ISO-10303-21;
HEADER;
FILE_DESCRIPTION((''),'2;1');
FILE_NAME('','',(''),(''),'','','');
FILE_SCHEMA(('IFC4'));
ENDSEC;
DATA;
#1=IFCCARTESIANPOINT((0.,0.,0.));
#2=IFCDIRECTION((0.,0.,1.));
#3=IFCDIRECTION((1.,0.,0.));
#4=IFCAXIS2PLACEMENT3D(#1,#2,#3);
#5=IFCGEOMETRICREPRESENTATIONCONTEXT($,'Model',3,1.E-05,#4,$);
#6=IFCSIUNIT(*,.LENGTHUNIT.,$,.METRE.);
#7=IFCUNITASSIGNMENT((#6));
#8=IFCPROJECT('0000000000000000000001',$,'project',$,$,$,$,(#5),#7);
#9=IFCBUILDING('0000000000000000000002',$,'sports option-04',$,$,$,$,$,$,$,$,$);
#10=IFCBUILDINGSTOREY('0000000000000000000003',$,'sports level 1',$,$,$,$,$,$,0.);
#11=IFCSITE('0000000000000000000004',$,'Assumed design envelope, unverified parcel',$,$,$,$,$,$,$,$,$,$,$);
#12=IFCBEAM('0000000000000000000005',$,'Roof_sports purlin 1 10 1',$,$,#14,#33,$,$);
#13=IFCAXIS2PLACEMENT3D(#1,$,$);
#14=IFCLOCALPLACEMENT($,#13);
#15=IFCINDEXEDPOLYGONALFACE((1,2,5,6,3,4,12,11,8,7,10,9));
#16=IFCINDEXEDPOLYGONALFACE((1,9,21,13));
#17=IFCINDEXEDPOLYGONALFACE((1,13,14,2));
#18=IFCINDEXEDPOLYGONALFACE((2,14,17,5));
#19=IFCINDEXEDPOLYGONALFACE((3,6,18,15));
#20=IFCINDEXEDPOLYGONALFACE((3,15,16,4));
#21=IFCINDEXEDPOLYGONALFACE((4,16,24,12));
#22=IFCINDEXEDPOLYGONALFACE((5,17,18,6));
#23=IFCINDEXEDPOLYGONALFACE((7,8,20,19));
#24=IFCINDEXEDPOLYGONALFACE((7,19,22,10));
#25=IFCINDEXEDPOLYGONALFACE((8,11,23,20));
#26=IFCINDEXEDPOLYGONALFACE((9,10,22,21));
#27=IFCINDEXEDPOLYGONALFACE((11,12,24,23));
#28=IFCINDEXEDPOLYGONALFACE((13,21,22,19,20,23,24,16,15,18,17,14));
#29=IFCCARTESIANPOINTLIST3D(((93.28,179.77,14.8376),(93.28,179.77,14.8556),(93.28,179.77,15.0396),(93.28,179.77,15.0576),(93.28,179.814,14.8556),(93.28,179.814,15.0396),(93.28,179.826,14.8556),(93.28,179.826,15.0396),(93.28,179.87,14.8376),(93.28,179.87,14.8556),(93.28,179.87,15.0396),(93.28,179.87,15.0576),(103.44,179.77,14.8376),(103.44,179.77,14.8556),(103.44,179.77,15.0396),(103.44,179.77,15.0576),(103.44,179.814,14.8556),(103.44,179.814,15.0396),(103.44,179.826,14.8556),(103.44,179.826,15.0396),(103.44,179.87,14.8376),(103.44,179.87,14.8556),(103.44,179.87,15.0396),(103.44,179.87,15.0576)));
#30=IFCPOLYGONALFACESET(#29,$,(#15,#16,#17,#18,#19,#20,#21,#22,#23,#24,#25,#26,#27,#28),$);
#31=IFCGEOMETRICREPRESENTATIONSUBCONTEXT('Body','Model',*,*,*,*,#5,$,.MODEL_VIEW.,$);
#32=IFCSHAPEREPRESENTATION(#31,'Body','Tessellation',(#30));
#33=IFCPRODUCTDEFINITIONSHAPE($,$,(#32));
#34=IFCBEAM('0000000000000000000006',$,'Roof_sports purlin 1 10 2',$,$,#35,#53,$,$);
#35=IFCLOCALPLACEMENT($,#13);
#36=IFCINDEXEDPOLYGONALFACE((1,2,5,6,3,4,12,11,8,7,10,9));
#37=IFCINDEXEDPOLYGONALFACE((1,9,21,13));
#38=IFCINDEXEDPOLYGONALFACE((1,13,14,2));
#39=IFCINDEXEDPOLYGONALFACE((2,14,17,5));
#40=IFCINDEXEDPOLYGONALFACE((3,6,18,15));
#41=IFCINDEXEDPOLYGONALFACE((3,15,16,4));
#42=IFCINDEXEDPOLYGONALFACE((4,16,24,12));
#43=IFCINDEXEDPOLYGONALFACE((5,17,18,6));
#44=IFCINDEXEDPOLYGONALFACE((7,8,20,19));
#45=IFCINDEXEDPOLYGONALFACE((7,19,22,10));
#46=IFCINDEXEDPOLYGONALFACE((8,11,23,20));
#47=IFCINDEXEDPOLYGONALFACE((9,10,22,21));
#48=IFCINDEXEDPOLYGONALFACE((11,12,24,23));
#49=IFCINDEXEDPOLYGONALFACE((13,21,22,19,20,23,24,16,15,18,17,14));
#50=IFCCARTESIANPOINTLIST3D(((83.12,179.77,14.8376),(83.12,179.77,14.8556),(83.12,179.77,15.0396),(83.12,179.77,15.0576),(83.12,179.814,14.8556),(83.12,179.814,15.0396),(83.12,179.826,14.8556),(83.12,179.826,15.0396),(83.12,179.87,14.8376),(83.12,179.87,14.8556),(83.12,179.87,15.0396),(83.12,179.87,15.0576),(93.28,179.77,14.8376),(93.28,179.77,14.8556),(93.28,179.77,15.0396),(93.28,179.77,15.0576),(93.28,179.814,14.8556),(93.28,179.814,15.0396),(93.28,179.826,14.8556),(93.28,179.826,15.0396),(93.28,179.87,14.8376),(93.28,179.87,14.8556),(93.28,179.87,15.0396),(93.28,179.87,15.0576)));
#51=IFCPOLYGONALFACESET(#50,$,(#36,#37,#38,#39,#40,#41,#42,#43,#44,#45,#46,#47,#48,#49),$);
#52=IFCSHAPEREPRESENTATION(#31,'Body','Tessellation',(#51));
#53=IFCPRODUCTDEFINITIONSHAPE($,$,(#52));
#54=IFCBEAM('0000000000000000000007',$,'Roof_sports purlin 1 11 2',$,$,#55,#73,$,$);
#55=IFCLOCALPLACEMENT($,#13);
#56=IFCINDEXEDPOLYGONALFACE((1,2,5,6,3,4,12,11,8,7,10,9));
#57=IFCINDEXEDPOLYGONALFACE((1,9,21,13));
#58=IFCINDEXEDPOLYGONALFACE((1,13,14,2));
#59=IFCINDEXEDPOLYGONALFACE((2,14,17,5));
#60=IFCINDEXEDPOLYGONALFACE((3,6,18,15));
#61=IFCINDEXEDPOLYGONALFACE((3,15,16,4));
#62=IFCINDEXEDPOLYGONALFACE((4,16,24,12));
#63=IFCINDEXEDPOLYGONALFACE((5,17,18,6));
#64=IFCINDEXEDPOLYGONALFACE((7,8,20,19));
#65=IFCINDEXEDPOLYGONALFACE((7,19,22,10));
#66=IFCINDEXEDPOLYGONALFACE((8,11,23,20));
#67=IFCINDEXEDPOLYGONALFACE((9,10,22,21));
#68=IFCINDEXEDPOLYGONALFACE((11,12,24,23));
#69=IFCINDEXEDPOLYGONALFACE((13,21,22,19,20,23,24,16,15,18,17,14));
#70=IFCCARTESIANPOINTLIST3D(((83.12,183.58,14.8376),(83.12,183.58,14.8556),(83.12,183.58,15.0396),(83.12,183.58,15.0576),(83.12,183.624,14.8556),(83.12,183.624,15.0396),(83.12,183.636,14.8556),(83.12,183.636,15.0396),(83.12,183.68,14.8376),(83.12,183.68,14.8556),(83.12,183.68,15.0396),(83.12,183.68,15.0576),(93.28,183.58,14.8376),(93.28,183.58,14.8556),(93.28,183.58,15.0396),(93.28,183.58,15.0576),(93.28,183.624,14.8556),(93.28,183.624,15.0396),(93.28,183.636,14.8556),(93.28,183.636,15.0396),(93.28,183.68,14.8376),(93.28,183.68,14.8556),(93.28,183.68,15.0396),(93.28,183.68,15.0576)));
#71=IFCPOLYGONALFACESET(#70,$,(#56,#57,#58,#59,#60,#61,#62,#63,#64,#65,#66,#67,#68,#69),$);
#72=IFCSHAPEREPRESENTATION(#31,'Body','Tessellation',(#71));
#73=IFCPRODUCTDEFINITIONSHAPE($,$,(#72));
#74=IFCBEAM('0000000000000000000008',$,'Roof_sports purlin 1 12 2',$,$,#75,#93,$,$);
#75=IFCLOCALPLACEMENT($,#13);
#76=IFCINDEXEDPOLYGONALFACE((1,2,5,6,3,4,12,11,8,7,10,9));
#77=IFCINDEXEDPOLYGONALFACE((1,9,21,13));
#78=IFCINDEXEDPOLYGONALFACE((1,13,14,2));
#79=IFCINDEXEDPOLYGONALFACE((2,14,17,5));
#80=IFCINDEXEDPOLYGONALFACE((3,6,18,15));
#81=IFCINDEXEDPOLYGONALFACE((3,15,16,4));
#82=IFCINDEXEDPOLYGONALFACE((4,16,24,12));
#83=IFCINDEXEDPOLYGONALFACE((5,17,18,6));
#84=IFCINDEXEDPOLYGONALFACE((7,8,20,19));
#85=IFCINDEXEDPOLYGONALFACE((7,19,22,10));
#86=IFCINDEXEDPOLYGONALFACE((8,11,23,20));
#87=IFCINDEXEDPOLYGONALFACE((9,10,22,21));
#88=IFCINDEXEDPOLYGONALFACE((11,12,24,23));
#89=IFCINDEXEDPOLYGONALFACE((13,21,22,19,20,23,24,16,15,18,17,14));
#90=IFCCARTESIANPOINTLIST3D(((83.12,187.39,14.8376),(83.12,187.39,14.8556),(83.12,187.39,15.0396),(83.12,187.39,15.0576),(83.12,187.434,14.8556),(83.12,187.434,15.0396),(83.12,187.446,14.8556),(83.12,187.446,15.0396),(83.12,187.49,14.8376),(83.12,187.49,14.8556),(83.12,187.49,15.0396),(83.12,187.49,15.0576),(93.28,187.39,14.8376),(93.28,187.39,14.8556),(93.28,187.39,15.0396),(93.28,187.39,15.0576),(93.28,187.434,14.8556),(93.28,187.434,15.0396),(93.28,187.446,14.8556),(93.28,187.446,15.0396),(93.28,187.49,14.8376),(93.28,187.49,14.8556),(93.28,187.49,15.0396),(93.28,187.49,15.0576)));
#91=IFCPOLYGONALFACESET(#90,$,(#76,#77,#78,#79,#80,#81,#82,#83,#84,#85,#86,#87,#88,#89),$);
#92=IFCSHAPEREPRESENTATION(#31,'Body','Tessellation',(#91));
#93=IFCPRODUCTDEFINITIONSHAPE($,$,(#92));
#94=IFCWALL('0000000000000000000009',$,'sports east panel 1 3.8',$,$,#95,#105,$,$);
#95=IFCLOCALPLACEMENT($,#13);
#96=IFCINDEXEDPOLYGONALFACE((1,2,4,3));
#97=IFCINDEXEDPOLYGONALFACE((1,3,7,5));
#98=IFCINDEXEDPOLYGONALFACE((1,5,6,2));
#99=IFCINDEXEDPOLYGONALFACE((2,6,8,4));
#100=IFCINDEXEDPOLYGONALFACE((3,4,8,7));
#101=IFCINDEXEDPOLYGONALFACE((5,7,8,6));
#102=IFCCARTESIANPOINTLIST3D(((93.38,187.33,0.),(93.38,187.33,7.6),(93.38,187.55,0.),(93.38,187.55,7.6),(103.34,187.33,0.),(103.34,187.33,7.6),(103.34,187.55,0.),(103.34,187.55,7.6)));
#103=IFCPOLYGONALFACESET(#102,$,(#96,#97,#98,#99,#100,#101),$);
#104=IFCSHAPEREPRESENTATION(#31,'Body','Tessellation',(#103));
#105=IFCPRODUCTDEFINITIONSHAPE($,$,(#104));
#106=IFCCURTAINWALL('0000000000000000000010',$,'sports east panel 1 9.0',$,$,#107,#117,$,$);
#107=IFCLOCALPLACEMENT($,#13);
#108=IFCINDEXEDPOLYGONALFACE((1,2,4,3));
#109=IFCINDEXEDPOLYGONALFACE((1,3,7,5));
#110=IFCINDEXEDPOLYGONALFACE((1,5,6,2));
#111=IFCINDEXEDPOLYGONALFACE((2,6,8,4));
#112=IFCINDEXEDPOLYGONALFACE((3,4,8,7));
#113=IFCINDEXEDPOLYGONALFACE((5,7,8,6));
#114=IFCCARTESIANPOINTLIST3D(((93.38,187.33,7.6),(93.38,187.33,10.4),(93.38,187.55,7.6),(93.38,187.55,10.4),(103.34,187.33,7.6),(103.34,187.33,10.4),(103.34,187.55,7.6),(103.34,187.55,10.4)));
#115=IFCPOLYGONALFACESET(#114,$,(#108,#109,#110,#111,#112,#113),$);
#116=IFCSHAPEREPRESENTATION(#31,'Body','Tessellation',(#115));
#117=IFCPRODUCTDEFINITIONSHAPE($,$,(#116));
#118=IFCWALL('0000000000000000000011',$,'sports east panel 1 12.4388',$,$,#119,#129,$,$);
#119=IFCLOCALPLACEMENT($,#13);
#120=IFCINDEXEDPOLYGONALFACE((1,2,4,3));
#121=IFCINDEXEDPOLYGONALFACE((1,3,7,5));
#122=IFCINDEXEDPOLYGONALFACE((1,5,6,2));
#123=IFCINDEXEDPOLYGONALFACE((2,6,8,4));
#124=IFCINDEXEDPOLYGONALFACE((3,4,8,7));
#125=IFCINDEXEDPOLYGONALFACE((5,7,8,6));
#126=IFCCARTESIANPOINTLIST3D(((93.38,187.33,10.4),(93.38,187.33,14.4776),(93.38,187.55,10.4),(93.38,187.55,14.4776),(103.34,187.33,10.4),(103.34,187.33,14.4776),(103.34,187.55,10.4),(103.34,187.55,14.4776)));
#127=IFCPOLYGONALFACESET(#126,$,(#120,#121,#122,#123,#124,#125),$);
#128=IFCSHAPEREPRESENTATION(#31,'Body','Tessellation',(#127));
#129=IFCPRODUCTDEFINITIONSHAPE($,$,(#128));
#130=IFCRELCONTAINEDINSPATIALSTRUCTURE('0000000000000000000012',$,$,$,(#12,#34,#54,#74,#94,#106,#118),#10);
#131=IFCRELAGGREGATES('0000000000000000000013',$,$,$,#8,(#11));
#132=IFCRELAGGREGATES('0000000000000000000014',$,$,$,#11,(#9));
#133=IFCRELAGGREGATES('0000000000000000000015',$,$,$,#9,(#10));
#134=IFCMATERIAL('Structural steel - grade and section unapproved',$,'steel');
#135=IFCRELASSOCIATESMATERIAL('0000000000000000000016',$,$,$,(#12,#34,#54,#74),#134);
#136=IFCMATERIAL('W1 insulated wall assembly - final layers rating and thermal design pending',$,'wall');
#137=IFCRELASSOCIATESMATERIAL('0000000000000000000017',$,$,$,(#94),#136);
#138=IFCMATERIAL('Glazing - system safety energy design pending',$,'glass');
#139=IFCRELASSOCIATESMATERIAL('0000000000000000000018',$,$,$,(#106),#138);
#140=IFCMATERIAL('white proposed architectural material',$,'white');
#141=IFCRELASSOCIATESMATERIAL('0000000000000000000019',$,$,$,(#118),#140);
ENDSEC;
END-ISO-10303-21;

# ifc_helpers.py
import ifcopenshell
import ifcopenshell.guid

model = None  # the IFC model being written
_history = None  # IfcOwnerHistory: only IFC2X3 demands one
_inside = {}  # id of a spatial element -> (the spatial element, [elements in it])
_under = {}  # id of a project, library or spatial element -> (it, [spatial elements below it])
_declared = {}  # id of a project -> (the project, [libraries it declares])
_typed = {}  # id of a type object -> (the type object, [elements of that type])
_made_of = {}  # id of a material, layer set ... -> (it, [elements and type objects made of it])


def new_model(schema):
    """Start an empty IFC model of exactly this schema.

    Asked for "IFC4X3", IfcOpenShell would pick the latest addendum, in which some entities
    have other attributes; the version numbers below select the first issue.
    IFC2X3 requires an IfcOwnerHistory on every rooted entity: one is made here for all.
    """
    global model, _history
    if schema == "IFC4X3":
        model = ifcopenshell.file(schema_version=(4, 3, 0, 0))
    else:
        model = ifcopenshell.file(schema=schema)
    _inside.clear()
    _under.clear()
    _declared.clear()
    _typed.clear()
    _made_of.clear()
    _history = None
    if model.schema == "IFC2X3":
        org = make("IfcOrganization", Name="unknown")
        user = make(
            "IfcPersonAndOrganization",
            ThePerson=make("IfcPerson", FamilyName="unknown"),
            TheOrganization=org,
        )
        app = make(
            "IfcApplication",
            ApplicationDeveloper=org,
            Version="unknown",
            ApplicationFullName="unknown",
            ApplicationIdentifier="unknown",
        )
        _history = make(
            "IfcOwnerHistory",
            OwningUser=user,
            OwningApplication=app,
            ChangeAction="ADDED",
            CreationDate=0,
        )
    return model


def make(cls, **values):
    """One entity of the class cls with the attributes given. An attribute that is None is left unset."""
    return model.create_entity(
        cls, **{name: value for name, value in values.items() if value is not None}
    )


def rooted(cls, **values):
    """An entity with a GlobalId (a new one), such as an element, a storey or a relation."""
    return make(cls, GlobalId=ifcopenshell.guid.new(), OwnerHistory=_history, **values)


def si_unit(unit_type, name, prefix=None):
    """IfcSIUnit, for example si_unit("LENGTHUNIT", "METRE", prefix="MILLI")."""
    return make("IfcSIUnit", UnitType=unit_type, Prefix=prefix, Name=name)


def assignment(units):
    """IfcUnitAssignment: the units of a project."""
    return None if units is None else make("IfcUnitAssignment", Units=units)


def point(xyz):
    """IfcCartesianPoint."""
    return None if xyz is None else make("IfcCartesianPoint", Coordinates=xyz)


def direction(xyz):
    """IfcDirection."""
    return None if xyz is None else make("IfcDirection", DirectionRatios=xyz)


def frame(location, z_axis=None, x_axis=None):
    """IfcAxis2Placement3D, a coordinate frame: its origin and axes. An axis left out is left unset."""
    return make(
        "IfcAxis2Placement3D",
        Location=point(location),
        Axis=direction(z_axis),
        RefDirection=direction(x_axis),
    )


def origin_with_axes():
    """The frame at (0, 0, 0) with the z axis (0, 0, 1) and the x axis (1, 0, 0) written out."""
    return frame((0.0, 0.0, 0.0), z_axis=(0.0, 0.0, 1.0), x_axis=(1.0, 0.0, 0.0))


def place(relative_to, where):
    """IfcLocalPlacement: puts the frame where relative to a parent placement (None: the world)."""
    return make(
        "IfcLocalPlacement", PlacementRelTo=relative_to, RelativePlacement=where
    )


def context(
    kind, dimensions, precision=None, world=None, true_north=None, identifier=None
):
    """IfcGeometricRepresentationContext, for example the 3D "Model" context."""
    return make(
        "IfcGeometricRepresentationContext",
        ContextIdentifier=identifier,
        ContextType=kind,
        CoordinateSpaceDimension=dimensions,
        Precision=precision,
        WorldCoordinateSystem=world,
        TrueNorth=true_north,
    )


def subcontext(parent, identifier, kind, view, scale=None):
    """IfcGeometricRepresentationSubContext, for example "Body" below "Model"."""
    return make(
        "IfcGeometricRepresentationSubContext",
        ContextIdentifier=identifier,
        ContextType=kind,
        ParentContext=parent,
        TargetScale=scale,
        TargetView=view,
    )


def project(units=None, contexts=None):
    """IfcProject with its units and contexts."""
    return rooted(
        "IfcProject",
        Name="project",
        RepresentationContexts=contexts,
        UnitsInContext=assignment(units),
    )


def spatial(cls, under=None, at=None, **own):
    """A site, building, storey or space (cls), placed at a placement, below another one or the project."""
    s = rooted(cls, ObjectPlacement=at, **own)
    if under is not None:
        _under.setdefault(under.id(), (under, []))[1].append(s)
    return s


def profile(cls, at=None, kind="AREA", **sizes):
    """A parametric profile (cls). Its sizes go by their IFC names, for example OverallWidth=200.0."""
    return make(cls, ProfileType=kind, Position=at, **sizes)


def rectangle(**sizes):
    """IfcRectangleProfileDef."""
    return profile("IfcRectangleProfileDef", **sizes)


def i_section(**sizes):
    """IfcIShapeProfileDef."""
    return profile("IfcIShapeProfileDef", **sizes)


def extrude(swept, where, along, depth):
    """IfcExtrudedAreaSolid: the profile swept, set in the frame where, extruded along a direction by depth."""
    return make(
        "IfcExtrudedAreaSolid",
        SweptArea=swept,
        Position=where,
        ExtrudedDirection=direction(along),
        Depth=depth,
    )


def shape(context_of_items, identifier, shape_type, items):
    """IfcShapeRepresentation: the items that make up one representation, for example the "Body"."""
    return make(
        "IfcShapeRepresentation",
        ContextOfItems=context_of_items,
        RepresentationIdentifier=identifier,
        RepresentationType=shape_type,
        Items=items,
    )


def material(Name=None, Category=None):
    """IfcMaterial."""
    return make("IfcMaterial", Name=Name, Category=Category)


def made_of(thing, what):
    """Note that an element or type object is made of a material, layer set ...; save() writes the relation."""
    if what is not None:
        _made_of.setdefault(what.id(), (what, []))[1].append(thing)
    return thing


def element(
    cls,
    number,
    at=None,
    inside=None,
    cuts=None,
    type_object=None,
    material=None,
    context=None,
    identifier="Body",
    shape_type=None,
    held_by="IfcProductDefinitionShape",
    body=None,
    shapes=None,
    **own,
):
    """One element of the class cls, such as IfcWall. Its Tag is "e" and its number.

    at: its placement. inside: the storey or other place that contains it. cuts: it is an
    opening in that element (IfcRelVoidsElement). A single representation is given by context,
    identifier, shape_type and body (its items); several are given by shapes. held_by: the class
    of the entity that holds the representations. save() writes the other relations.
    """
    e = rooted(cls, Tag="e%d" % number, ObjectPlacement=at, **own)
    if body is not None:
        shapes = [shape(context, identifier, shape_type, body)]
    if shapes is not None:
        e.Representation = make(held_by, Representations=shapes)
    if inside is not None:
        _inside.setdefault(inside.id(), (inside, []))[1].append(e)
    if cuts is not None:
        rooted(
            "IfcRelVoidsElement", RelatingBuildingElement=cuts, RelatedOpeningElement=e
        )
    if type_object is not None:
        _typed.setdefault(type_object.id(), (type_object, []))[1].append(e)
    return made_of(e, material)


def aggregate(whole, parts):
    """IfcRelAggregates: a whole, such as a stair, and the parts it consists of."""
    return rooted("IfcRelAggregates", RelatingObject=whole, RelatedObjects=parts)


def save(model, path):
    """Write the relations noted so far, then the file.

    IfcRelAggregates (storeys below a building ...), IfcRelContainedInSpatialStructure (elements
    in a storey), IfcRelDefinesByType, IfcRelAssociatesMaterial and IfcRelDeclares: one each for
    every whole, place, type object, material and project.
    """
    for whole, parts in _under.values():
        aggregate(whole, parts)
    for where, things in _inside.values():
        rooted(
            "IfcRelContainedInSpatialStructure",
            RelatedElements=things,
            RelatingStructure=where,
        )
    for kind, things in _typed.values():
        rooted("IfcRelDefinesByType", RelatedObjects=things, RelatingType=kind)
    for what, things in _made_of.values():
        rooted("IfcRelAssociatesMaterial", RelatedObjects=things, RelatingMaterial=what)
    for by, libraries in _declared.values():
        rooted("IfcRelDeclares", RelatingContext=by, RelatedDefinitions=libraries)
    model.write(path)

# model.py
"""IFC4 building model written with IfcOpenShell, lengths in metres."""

from ifc_helpers import new_model, si_unit, frame, origin_with_axes, place, context, subcontext, project, spatial, rectangle, i_section, extrude, material, element, save


model = new_model("IFC4")

# Units and contexts
model_context = context("Model", 3, precision=1e-05, world=origin_with_axes())
body_context = subcontext(model_context, "Body", "Model", "MODEL_VIEW")
ifc_project = project(units=[si_unit("LENGTHUNIT", "METRE")], contexts=[model_context])

# Site, building, storey
site = spatial("IfcSite", under=ifc_project, Name="Assumed design envelope, unverified parcel")
building = spatial("IfcBuilding", under=site, Name="sports option-04")
storey = spatial("IfcBuildingStorey", under=building, Name="sports level 1", Elevation=0.0)

# Shared definitions
ifc_material_1 = material(Name="Structural steel - grade and section unapproved", Category="steel")

# Beams
beam_1_placement = place(None, frame((103.44, 179.82, 14.9476), z_axis=(-1.0, 0.0, 0.0), x_axis=(0.0, -1.0, 0.0)))
element("IfcBeam", 1, at=beam_1_placement, inside=storey, material=ifc_material_1, Name="Roof_sports purlin 1 10 1", context=body_context, shape_type="SweptSolid", body=[
    extrude(i_section(OverallWidth=0.1, OverallDepth=0.22, WebThickness=0.012, FlangeThickness=0.018, FilletRadius=0.0), origin_with_axes(), (0.0, 0.0, 1.0), 10.16),
])
for number, where, z_axis, x_axis, name in (
    (2, (93.28, 179.82, 14.9476), (-1.0, 0.0, 0.0), (0.0, -1.0, 0.0), "Roof_sports purlin 1 10 2"),
    (3, (93.28, 183.63, 14.9476), (-1.0, 0.0, 0.0), (0.0, -1.0, 0.0), "Roof_sports purlin 1 11 2"),
    (4, (93.28, 187.44, 14.9476), (-1.0, 0.0, 0.0), (0.0, -1.0, 0.0), "Roof_sports purlin 1 12 2"),
):
    element("IfcBeam", number, at=place(None, frame(where, z_axis=z_axis, x_axis=x_axis)), inside=storey, material=ifc_material_1, Name=name, context=body_context, shape_type="SweptSolid", body=[
        extrude(i_section(OverallWidth=0.1, OverallDepth=0.22, WebThickness=0.012, FlangeThickness=0.018, FilletRadius=0.0), origin_with_axes(), (0.0, 0.0, 1.0), 10.16),
    ])

# Wall
ifc_material_2 = material(Name="W1 insulated wall assembly - final layers rating and thermal design pending", Category="wall")
wall_1_placement = place(None, frame((98.36, 187.44, 0.0), z_axis=(0.0, 0.0, 1.0), x_axis=(0.0, 1.0, 0.0)))
element("IfcWall", 5, at=wall_1_placement, inside=storey, material=ifc_material_2, Name="sports east panel 1 3.8", context=body_context, shape_type="SweptSolid", body=[
    extrude(rectangle(XDim=0.22, YDim=9.96), origin_with_axes(), (0.0, 0.0, 1.0), 7.6),
])

# Curtain wall
ifc_material_3 = material(Name="Glazing - system safety energy design pending", Category="glass")
curtain_wall_placement = place(None, frame((98.36, 187.44, 7.6), z_axis=(0.0, 0.0, 1.0), x_axis=(0.0, 1.0, 0.0)))
element("IfcCurtainWall", 6, at=curtain_wall_placement, inside=storey, material=ifc_material_3, Name="sports east panel 1 9.0", context=body_context, shape_type="SweptSolid", body=[
    extrude(rectangle(XDim=0.22, YDim=9.96), origin_with_axes(), (0.0, 0.0, 1.0), 2.8),
])

# Wall
ifc_material_4 = material(Name="white proposed architectural material", Category="white")
wall_2_placement = place(None, frame((98.36, 187.44, 10.4), z_axis=(0.0, 0.0, 1.0), x_axis=(0.0, 1.0, 0.0)))
element("IfcWall", 7, at=wall_2_placement, inside=storey, material=ifc_material_4, Name="sports east panel 1 12.4388", context=body_context, shape_type="SweptSolid", body=[
    extrude(rectangle(XDim=0.22, YDim=9.96), origin_with_axes(), (0.0, 0.0, 1.0), 4.0776),
])

save(model, "model.ifc")
